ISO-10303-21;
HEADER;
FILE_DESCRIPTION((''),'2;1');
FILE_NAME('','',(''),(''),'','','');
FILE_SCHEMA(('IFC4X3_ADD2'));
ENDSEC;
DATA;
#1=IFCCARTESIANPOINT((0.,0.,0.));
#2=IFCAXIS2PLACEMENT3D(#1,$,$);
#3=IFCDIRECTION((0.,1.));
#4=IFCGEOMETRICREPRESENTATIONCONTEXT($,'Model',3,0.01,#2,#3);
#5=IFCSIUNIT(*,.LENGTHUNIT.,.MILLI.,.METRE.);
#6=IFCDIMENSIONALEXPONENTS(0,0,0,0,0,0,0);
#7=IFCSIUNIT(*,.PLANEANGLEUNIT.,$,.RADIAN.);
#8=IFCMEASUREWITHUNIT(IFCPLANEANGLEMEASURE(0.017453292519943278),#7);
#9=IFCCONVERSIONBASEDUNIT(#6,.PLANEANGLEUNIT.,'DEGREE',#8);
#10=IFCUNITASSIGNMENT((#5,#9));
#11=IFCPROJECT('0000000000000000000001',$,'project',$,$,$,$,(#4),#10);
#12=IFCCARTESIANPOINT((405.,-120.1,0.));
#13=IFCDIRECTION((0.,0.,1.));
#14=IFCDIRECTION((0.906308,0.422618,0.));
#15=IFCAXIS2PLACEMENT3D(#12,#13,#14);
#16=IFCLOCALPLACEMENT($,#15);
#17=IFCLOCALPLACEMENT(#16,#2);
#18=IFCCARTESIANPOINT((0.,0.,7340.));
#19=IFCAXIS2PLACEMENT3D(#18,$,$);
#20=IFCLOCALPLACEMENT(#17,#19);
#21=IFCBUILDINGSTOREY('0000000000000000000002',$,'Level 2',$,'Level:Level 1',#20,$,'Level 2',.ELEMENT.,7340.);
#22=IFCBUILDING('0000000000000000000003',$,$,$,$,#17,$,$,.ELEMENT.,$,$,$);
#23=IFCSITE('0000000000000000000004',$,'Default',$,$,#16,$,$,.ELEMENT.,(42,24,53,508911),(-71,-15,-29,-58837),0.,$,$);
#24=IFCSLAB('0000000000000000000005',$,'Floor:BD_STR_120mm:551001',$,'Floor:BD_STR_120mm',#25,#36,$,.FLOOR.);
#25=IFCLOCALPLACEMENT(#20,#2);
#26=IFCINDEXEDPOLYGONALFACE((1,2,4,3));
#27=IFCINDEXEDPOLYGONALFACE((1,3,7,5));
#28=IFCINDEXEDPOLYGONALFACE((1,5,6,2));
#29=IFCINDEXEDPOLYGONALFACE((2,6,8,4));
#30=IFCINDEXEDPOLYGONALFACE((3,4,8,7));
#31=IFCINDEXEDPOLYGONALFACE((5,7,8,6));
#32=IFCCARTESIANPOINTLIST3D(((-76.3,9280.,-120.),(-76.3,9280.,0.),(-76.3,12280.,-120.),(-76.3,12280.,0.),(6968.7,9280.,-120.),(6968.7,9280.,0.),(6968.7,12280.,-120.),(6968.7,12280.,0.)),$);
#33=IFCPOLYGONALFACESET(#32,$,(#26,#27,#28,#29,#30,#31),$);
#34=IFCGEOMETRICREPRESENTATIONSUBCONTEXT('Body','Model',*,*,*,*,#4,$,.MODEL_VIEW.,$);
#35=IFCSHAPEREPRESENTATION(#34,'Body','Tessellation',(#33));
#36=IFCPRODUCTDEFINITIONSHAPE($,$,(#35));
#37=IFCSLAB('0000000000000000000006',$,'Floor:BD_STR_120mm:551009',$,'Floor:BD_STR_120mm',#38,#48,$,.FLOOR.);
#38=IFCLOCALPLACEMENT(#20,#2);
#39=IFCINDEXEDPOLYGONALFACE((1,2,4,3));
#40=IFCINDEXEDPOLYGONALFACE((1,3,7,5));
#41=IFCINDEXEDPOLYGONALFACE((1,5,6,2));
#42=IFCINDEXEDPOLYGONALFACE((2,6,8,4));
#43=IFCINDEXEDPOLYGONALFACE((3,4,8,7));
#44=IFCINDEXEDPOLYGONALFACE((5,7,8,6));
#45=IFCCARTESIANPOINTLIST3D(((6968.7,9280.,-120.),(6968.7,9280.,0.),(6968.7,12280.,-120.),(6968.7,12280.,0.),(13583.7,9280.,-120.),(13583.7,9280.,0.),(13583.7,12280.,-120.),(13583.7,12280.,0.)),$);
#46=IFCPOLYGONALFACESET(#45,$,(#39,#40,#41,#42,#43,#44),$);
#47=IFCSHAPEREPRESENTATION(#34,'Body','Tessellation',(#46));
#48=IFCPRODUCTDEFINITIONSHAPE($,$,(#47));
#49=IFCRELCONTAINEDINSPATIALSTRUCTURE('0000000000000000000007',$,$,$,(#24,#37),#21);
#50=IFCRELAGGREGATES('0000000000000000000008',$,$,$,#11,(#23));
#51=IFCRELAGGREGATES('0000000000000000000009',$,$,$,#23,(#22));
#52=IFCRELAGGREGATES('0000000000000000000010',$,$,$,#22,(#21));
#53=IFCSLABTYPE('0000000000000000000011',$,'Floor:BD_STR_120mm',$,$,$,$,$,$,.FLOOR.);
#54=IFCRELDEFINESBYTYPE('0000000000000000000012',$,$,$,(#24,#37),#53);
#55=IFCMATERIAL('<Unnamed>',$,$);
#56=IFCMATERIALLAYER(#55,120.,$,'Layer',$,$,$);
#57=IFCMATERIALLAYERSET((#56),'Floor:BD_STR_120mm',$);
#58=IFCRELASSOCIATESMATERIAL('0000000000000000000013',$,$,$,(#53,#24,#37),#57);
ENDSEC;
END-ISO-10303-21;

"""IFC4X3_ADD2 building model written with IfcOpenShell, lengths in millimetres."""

from ifc_helpers import new_model, entity, si_unit, converted_unit, direction, frame, frame_2d, origin, origin_2d_with_axis, place, context, subcontext, project, spatial, rectangle, extrude, material, layer, layer_set, layer_usage, type_object, element, save


model = new_model("IFC4X3_ADD2")

# Units and contexts
model_context = context("Model", 3, precision=0.01, world=origin(), true_north=direction((0.0, 1.0)))
body_context = subcontext(model_context, "Body", "Model", "MODEL_VIEW")
ifc_project = project(units=[si_unit("LENGTHUNIT", "METRE", prefix="MILLI"), converted_unit("PLANEANGLEUNIT", "DEGREE", entity("IfcPlaneAngleMeasure", 0.017453292519943278), si_unit("PLANEANGLEUNIT", "RADIAN"), dimensions=[0, 0, 0, 0, 0, 0, 0])], contexts=[model_context])

# Site, building, storey
site_placement = place(None, frame((405.0, -120.1, 0.0), z_axis=(0.0, 0.0, 1.0), x_axis=(0.906308, 0.422618, 0.0)))
site = spatial("IfcSite", under=ifc_project, at=site_placement, Name="Default", CompositionType="ELEMENT", RefLatitude=(42, 24, 53, 508911), RefLongitude=(-71, -15, -29, -58837), RefElevation=0.0)
building_placement = place(site_placement, origin())
building = spatial("IfcBuilding", under=site, at=building_placement, CompositionType="ELEMENT")
storey_placement = place(building_placement, frame((0.0, 0.0, 7340.0)))
storey = spatial("IfcBuildingStorey", under=building, at=storey_placement, Name="Level 2", ObjectType="Level:Level 1", LongName="Level 2", CompositionType="ELEMENT", Elevation=7340.0)

# Slabs
ifc_material = material(Name="<Unnamed>")
ifc_layer = layer(ifc_material, 120.0, Name="Layer")
ifc_layer_set = layer_set([ifc_layer], Name="Floor:BD_STR_120mm")
slab_type = type_object("IfcSlabType", Name="Floor:BD_STR_120mm", PredefinedType="FLOOR", material=ifc_layer_set)
ifc_layer_usage_1 = layer_usage(ifc_layer_set, "AXIS3", "POSITIVE", 0.0)
slab_1_placement = place(storey_placement, origin())
element("IfcSlab", 1, at=slab_1_placement, inside=storey, type_object=slab_type, material=ifc_layer_usage_1, Name="Floor:BD_STR_120mm:551001", ObjectType="Floor:BD_STR_120mm", PredefinedType="FLOOR", context=body_context, shape_type="SweptSolid", body=[
    extrude(rectangle(XDim=3000.0, YDim=7045.0, at=origin_2d_with_axis()), frame((3446.2, 10780.0, 0.0), z_axis=(0.0, 0.0, -1.0), x_axis=(0.0, 1.0, 0.0)), (0.0, 0.0, 1.0), 120.0),
])
ifc_layer_usage_2 = layer_usage(ifc_layer_set, "AXIS3", "POSITIVE", 0.0)
slab_2_placement = place(storey_placement, origin())
element("IfcSlab", 2, at=slab_2_placement, inside=storey, type_object=slab_type, material=ifc_layer_usage_2, Name="Floor:BD_STR_120mm:551009", ObjectType="Floor:BD_STR_120mm", PredefinedType="FLOOR", context=body_context, shape_type="SweptSolid", body=[
    extrude(rectangle(XDim=3000.0, YDim=6615.0, at=frame_2d((0.0, 0.0), x_axis=(1.0, 0.0))), frame((10276.2, 10780.0, 0.0), z_axis=(0.0, 0.0, -1.0), x_axis=(0.0, 1.0, 0.0)), (0.0, 0.0, 1.0), 120.0),
])

save(model, "model.ifc")
